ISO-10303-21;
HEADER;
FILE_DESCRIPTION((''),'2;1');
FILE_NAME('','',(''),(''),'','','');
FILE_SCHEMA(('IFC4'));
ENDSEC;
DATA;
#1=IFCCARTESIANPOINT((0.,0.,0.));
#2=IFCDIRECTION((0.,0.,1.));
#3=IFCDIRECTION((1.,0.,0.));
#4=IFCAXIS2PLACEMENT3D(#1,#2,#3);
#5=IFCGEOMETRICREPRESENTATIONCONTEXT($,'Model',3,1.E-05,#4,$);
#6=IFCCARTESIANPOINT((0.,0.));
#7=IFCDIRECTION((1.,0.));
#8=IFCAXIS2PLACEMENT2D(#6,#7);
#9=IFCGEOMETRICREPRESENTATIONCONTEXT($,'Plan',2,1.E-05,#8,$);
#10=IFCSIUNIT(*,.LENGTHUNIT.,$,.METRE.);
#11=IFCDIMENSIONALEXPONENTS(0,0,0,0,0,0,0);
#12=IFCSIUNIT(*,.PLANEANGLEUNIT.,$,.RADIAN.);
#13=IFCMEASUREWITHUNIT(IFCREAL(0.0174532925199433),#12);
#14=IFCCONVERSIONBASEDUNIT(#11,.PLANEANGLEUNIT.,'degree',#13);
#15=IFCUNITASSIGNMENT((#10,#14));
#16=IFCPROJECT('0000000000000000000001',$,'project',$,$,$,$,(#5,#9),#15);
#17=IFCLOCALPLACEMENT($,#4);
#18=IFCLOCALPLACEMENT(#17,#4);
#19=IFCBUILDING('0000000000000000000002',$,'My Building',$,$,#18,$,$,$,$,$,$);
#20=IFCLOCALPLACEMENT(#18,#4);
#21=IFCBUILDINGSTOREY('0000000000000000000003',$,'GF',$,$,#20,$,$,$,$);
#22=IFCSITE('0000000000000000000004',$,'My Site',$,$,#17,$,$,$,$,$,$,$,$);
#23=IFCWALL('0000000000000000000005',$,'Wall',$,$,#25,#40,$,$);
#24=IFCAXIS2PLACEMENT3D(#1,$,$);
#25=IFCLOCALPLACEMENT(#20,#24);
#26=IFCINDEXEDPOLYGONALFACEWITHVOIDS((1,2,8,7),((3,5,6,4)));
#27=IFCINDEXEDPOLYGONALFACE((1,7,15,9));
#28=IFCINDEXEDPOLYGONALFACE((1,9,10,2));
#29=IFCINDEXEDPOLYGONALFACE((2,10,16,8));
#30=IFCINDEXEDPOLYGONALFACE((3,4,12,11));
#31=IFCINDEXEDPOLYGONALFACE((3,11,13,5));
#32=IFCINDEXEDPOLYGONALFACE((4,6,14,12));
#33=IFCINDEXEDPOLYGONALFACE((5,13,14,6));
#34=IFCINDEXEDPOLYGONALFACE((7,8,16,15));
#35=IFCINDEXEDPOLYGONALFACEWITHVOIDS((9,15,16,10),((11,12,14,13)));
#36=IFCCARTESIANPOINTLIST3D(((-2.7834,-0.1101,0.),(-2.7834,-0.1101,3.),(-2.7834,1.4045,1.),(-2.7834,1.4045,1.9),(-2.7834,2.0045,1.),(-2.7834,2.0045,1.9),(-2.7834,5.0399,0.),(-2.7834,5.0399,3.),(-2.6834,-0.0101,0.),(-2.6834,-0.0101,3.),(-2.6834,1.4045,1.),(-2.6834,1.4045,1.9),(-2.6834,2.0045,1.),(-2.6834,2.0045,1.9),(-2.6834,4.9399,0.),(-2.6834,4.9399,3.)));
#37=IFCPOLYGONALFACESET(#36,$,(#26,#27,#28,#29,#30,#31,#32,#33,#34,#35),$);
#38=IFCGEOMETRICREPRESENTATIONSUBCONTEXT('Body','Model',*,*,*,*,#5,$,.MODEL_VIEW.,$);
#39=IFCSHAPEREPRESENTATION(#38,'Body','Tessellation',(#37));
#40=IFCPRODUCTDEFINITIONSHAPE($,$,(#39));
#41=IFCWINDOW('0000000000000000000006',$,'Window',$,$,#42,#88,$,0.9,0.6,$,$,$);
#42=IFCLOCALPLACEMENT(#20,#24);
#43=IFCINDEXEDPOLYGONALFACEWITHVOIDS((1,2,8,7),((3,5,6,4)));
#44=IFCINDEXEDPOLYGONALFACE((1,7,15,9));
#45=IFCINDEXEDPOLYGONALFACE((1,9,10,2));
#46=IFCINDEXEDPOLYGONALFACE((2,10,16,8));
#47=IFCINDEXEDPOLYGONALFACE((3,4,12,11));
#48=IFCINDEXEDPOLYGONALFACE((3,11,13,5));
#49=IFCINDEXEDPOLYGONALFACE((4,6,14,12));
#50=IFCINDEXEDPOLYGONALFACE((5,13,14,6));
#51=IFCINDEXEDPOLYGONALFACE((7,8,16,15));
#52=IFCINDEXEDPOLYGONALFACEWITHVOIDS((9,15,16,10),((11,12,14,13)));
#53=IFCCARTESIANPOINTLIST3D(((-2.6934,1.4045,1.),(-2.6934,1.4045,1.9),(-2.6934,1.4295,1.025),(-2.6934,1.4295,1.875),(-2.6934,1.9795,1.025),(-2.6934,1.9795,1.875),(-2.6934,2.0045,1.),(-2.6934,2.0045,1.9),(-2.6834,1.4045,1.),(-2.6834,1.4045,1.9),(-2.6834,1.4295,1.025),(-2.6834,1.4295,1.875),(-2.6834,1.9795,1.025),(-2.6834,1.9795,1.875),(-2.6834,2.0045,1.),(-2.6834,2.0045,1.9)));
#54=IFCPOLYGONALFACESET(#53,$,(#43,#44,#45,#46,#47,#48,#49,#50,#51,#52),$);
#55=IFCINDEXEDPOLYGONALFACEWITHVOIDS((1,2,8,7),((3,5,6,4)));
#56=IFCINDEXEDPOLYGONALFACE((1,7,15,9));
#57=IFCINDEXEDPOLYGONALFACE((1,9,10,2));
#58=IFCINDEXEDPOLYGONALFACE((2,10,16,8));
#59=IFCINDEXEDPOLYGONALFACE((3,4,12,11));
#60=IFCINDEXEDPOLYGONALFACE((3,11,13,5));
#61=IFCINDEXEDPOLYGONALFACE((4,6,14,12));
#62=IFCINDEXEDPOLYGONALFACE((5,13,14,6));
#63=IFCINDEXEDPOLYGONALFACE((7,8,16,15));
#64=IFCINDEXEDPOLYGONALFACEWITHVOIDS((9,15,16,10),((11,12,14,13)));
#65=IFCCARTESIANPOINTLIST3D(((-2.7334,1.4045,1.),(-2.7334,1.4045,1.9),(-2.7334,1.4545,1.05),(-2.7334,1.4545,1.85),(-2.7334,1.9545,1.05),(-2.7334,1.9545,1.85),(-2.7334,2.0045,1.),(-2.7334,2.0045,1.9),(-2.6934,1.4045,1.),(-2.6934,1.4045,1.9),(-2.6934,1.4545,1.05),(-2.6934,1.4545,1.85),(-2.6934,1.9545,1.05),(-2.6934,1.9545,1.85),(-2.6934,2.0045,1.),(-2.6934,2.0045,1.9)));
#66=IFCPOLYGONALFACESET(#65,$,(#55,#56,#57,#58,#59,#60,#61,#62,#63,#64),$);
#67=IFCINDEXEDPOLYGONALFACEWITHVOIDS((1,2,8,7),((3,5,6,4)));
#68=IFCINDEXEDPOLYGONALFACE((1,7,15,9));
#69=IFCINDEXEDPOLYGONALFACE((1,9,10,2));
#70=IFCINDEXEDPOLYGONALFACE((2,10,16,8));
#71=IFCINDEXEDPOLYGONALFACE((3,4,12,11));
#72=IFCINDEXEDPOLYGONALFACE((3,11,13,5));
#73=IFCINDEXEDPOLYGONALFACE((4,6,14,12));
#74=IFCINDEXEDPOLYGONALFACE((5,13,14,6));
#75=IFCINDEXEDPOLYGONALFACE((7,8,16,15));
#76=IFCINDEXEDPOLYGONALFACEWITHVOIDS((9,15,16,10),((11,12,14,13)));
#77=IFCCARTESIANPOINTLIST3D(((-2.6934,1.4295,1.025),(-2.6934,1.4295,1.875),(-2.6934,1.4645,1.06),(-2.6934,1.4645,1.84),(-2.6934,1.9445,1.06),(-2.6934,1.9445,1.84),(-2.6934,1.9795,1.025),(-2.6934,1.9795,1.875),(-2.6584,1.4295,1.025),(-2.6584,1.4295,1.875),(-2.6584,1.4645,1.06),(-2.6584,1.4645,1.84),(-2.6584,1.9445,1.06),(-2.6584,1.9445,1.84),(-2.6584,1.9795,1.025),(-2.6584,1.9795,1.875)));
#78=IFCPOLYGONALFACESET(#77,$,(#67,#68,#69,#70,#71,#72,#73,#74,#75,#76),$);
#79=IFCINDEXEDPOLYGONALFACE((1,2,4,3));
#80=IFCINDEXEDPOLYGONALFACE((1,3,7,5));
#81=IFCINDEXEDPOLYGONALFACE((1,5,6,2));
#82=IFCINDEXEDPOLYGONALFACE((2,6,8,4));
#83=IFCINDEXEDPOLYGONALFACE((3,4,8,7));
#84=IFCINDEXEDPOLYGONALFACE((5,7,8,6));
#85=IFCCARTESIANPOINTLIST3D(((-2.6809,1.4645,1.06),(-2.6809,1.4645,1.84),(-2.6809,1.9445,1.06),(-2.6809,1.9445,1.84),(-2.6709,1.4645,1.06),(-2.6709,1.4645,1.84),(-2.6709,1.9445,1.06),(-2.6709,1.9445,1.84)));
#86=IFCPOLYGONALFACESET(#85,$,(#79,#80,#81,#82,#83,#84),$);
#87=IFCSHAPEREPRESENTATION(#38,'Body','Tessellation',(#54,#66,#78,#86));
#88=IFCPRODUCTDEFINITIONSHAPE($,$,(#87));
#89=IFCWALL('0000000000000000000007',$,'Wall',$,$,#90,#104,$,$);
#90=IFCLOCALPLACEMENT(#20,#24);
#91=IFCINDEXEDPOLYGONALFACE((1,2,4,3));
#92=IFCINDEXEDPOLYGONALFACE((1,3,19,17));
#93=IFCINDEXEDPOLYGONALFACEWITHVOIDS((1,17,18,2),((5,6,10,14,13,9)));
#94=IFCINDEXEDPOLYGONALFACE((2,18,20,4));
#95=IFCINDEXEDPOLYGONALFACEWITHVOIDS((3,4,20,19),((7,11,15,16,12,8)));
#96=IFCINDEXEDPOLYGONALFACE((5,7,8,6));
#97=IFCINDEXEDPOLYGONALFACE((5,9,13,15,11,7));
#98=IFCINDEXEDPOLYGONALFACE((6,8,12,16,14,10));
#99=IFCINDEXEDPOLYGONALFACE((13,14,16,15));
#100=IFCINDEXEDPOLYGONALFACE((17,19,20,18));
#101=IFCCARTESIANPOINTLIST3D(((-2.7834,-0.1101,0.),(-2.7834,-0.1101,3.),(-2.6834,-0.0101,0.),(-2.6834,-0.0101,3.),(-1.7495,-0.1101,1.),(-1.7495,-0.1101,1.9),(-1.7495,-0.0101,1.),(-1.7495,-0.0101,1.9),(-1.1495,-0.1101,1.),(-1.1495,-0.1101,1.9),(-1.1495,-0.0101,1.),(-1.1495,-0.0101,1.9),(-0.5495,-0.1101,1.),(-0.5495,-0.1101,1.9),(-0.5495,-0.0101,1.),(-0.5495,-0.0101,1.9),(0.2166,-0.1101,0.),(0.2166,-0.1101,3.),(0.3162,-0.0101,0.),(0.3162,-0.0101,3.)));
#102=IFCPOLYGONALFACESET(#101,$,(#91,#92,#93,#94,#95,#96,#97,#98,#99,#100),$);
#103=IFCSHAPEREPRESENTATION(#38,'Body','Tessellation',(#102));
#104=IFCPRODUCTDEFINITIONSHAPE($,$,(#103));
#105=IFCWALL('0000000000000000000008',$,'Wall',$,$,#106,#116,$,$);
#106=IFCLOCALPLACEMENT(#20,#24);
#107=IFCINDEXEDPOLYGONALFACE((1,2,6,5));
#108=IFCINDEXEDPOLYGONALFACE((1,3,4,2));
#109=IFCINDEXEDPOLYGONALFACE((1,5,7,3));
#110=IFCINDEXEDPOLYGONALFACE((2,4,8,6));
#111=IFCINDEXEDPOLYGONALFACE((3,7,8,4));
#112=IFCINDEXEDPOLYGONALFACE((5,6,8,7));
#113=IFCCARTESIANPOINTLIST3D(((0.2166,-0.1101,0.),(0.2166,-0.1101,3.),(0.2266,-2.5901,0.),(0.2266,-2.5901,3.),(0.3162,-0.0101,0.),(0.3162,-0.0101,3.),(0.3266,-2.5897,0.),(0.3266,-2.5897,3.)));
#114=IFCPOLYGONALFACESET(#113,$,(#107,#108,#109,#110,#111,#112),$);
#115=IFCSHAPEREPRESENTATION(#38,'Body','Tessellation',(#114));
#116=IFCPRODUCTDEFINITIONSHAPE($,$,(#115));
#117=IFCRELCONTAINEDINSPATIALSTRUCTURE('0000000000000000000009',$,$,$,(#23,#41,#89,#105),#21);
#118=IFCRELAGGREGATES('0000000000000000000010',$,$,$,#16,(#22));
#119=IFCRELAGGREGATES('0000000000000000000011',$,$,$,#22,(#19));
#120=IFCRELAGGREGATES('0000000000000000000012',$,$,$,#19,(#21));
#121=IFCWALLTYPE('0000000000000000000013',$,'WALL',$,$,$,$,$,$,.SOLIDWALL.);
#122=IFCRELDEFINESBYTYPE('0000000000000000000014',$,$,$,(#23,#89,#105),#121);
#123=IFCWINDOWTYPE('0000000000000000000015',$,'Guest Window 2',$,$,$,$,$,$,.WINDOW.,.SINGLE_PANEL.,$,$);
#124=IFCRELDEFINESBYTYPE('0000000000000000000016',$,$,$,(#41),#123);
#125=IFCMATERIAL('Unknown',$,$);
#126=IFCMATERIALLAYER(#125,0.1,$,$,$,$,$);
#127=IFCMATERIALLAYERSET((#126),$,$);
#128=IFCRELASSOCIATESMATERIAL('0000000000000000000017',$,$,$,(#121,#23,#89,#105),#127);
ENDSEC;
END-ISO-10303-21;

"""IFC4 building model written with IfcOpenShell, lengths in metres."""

from ifc_helpers import new_model, entity, si_unit, converted_unit, frame, origin_with_axes, origin_2d_with_axis, place, context, subcontext, project, spatial, line, indexed_curve, outline, extrude, shape, source, transform, mapped, material, layer, layer_set, layer_usage, type_object, type_shapes, element, fill, save


model = new_model("IFC4")

# Units and contexts
model_context = context("Model", 3, precision=1e-05, world=origin_with_axes())
plan_context = context("Plan", 2, precision=1e-05, world=origin_2d_with_axis())
body_context_1 = subcontext(model_context, "Body", "Model", "MODEL_VIEW")
body_context_2 = subcontext(plan_context, "Body", "Plan", "PLAN_VIEW")
ifc_project = project(units=[si_unit("LENGTHUNIT", "METRE"), converted_unit("PLANEANGLEUNIT", "degree", entity("IfcReal", 0.0174532925199433), si_unit("PLANEANGLEUNIT", "RADIAN"), dimensions=[0, 0, 0, 0, 0, 0, 0])], contexts=[model_context, plan_context])

# Site, building, storey
site_placement = place(None, origin_with_axes())
site = spatial("IfcSite", under=ifc_project, at=site_placement, Name="My Site")
building_placement = place(site_placement, origin_with_axes())
building = spatial("IfcBuilding", under=site, at=building_placement, Name="My Building")
storey_placement = place(building_placement, origin_with_axes())
storey = spatial("IfcBuildingStorey", under=building, at=storey_placement, Name="GF")

# Shared definitions
ifc_material = material(Name="Unknown")

# Shared definitions
ifc_layer_1 = layer(ifc_material, 0.1)
ifc_layer_set_1 = layer_set([ifc_layer_1])
wall_type = type_object("IfcWallType", Name="WALL", PredefinedType="SOLIDWALL", material=ifc_layer_set_1)

# Wall, opening, window
ifc_layer_usage_1 = layer_usage(ifc_layer_set_1, "AXIS2", "POSITIVE", 0.0)
wall_1_placement = place(storey_placement, frame((-2.7834, 5.0399, 0.0), z_axis=(0.0, 0.0, 1.0), x_axis=(0.0, -1.0, 0.0)))
wall_1 = element("IfcWall", 1, at=wall_1_placement, inside=storey, type_object=wall_type, material=ifc_layer_usage_1, Name="Wall", context=body_context_1, shape_type="SweptSolid", body=[
    extrude(outline(indexed_curve([(0.0, 0.0), (0.1, 0.1), (5.05, 0.1), (5.15, 0.0)], segments=[line(1, 2, 3, 4, 1)])), origin_with_axes(), (0.0, 0.0, 1.0), 3.0),
])
shared_shape_1 = source(origin_with_axes(), body_context_1, "Body", "SweptSolid", [
    extrude(outline(indexed_curve([(0.0, 0.0), (0.6, 0.0), (0.6, 0.9), (0.0, 0.9)], segments=[line(1, 2, 3, 4, 1)])), frame((0.0, -0.6, 0.0), z_axis=(0.0, -1.0, 0.0), x_axis=(1.0, 0.0, 0.0)), (0.0, 0.0, -1.0), 1.2),
])
opening_1_placement = place(wall_1_placement, frame((3.0354, 0.0, 1.0), z_axis=(0.0, 0.0, 1.0), x_axis=(1.0, 0.0, 0.0)))
opening_1 = element("IfcOpeningElement", 2, at=opening_1_placement, cuts=wall_1, PredefinedType="OPENING", context=body_context_1, shape_type="MappedRepresentation", body=[
    mapped(shared_shape_1, transform((0.0, 0.0, 0.0), x_axis=(1.0, 0.0, 0.0), y_axis=(0.0, 1.0, 0.0), z_axis=(0.0, 0.0, 1.0), scale=1.0)),
])
window_type_1 = type_object("IfcWindowType", Name="Guest Window 2", PartitioningType="SINGLE_PANEL", PredefinedType="WINDOW")
shared_shape_2 = source(origin_with_axes(), body_context_1, "Body", "SweptSolid", [
    extrude(outline(indexed_curve([(0.0, 0.0), (0.6, 0.0), (0.6, 0.9), (0.0, 0.9)], segments=[line(1, 2, 3, 4, 1)]), holes=[indexed_curve([(0.025, 0.025), (0.575, 0.025), (0.575, 0.875), (0.025, 0.875)], segments=[line(1, 2, 3, 4, 1)])]), frame((0.0, 0.09, 0.0), z_axis=(0.0, -1.0, 0.0), x_axis=(1.0, 0.0, 0.0)), (0.0, 0.0, -1.0), 0.01),
    extrude(outline(indexed_curve([(0.0, 0.0), (0.6, 0.0), (0.6, 0.9), (0.0, 0.9)], segments=[line(1, 2, 3, 4, 1)]), holes=[indexed_curve([(0.05, 0.05), (0.55, 0.05), (0.55, 0.85), (0.05, 0.85)], segments=[line(1, 2, 3, 4, 1)])]), frame((0.0, 0.05, 0.0), z_axis=(0.0, -1.0, 0.0), x_axis=(1.0, 0.0, 0.0)), (0.0, 0.0, -1.0), 0.04),
    extrude(outline(indexed_curve([(0.0, 0.0), (0.55, 0.0), (0.55, 0.85), (0.0, 0.85)], segments=[line(1, 2, 3, 4, 1)]), holes=[indexed_curve([(0.035, 0.035), (0.515, 0.035), (0.515, 0.815), (0.035, 0.815)], segments=[line(1, 2, 3, 4, 1)])]), frame((0.025, 0.09, 0.025), z_axis=(0.0, -1.0, 0.0), x_axis=(1.0, 0.0, 0.0)), (0.0, 0.0, -1.0), 0.035),
    extrude(outline(indexed_curve([(0.035, 0.035), (0.515, 0.035), (0.515, 0.815), (0.035, 0.815)], segments=[line(1, 2, 3, 4, 1)])), frame((0.025, 0.1025, 0.025), z_axis=(0.0, -1.0, 0.0), x_axis=(1.0, 0.0, 0.0)), (0.0, 0.0, -1.0), 0.01),
])
shared_shape_3 = source(origin_with_axes(), body_context_2, "Body", "Curve2D", [
    entity("IfcIndexedPolyCurve", entity("IfcCartesianPointList2D", [[0.05, 0.05], [0.55, 0.05]])),
    entity("IfcIndexedPolyCurve", entity("IfcCartesianPointList2D", [[0.0, 0.1], [0.025, 0.1], [0.025, 0.09], [0.05, 0.09], [0.05, 0.05], [0.0, 0.05]]), [entity("IfcLineIndex", [1, 2, 3, 4, 5, 6, 1])]),
    entity("IfcIndexedPolyCurve", entity("IfcCartesianPointList2D", [[0.6, 0.1], [0.575, 0.1], [0.575, 0.09], [0.55, 0.09], [0.55, 0.05], [0.6, 0.05]]), [entity("IfcLineIndex", [1, 2, 3, 4, 5, 6, 1])]),
    entity("IfcIndexedPolyCurve", entity("IfcCartesianPointList2D", [[0.025, 0.09], [0.06, 0.09], [0.06, 0.125], [0.025, 0.125]]), [entity("IfcLineIndex", [1, 2, 3, 4, 1])]),
    entity("IfcIndexedPolyCurve", entity("IfcCartesianPointList2D", [[0.575, 0.09], [0.54, 0.09], [0.54, 0.125], [0.575, 0.125]]), [entity("IfcLineIndex", [1, 2, 3, 4, 1])]),
    entity("IfcIndexedPolyCurve", entity("IfcCartesianPointList2D", [[0.06, 0.09], [0.54, 0.09]])),
    entity("IfcIndexedPolyCurve", entity("IfcCartesianPointList2D", [[0.06, 0.125], [0.54, 0.125]])),
    entity("IfcIndexedPolyCurve", entity("IfcCartesianPointList2D", [[0.06, 0.1075], [0.54, 0.1075]])),
])
type_shapes(window_type_1, [shared_shape_2, shared_shape_3])
window_1_placement = place(opening_1_placement, frame((0.0, 0.0, 0.0), z_axis=(0.0, 0.0, 1.0), x_axis=(1.0, 0.0, 0.0)))
window_1 = element("IfcWindow", 3, at=window_1_placement, inside=storey, type_object=window_type_1, Name="Window", OverallHeight=0.9, OverallWidth=0.6, shapes=[
    shape(body_context_1, "Body", "MappedRepresentation", [mapped(shared_shape_2, transform((0.0, 0.0, 0.0), x_axis=(1.0, 0.0, 0.0), y_axis=(0.0, 1.0, 0.0), z_axis=(0.0, 0.0, 1.0), scale=1.0))]),
    shape(body_context_2, "Body", "MappedRepresentation", [mapped(shared_shape_3, transform((0.0, 0.0, 0.0), x_axis=(1.0, 0.0, 0.0), y_axis=(0.0, 1.0, 0.0), z_axis=(0.0, 0.0, 1.0), scale=1.0))]),
])
fill(opening_1, window_1)

# Wall, openings
ifc_layer_usage_2 = layer_usage(ifc_layer_set_1, "AXIS2", "POSITIVE", 0.0)
wall_2_placement = place(storey_placement, frame((-2.7834, -0.1101, 0.0), z_axis=(0.0, 0.0, 1.0), x_axis=(1.0, 0.0, 0.0)))
wall_2 = element("IfcWall", 4, at=wall_2_placement, inside=storey, type_object=wall_type, material=ifc_layer_usage_2, Name="Wall", context=body_context_1, shape_type="SweptSolid", body=[
    extrude(outline(indexed_curve([(0.0, 0.0), (0.1, 0.1), (3.0996, 0.1), (3.0, 0.0)], segments=[line(1, 2, 3, 4, 1)])), origin_with_axes(), (0.0, 0.0, 1.0), 3.0),
])
shared_shape_4 = source(origin_with_axes(), body_context_1, "Body", "SweptSolid", [
    extrude(outline(indexed_curve([(0.0, 0.0), (0.6, 0.0), (0.6, 0.9), (0.0, 0.9)], segments=[line(1, 2, 3, 4, 1)])), frame((0.0, -0.6, 0.0), z_axis=(0.0, -1.0, 0.0), x_axis=(1.0, 0.0, 0.0)), (0.0, 0.0, -1.0), 1.2),
])
opening_2_placement = place(wall_2_placement, frame((1.0339, 0.0, 1.0), z_axis=(0.0, 0.0, 1.0), x_axis=(1.0, 0.0, 0.0)))
element("IfcOpeningElement", 5, at=opening_2_placement, cuts=wall_2, PredefinedType="OPENING", context=body_context_1, shape_type="MappedRepresentation", body=[
    mapped(shared_shape_4, transform((0.0, 0.0, 0.0), x_axis=(1.0, 0.0, 0.0), y_axis=(0.0, 1.0, 0.0), z_axis=(0.0, 0.0, 1.0), scale=1.0)),
])
opening_3_placement = place(wall_2_placement, frame((1.6339, 0.0, 1.0), z_axis=(0.0, 0.0, 1.0), x_axis=(1.0, 0.0, 0.0)))
element("IfcOpeningElement", 6, at=opening_3_placement, cuts=wall_2, PredefinedType="OPENING", context=body_context_1, shape_type="MappedRepresentation", body=[
    mapped(shared_shape_4, transform((0.0, 0.0, 0.0), x_axis=(1.0, 0.0, 0.0), y_axis=(0.0, 1.0, 0.0), z_axis=(0.0, 0.0, 1.0), scale=1.0)),
])

# Wall
ifc_layer_usage_3 = layer_usage(ifc_layer_set_1, "AXIS2", "POSITIVE", 0.0)
wall_3_placement = place(storey_placement, frame((0.2166, -0.1101, 0.0), z_axis=(0.0, 0.0, 1.0), x_axis=(0.004032, -0.999992, 0.0)))
element("IfcWall", 7, at=wall_3_placement, inside=storey, type_object=wall_type, material=ifc_layer_usage_3, Name="Wall", context=body_context_1, shape_type="SweptSolid", body=[
    extrude(outline(indexed_curve([(0.0, 0.0), (-0.0996, 0.1), (2.48, 0.1), (2.48, 0.0)], segments=[line(1, 2, 3, 4, 1)])), origin_with_axes(), (0.0, 0.0, 1.0), 3.0),
])

save(model, "model.ifc")
